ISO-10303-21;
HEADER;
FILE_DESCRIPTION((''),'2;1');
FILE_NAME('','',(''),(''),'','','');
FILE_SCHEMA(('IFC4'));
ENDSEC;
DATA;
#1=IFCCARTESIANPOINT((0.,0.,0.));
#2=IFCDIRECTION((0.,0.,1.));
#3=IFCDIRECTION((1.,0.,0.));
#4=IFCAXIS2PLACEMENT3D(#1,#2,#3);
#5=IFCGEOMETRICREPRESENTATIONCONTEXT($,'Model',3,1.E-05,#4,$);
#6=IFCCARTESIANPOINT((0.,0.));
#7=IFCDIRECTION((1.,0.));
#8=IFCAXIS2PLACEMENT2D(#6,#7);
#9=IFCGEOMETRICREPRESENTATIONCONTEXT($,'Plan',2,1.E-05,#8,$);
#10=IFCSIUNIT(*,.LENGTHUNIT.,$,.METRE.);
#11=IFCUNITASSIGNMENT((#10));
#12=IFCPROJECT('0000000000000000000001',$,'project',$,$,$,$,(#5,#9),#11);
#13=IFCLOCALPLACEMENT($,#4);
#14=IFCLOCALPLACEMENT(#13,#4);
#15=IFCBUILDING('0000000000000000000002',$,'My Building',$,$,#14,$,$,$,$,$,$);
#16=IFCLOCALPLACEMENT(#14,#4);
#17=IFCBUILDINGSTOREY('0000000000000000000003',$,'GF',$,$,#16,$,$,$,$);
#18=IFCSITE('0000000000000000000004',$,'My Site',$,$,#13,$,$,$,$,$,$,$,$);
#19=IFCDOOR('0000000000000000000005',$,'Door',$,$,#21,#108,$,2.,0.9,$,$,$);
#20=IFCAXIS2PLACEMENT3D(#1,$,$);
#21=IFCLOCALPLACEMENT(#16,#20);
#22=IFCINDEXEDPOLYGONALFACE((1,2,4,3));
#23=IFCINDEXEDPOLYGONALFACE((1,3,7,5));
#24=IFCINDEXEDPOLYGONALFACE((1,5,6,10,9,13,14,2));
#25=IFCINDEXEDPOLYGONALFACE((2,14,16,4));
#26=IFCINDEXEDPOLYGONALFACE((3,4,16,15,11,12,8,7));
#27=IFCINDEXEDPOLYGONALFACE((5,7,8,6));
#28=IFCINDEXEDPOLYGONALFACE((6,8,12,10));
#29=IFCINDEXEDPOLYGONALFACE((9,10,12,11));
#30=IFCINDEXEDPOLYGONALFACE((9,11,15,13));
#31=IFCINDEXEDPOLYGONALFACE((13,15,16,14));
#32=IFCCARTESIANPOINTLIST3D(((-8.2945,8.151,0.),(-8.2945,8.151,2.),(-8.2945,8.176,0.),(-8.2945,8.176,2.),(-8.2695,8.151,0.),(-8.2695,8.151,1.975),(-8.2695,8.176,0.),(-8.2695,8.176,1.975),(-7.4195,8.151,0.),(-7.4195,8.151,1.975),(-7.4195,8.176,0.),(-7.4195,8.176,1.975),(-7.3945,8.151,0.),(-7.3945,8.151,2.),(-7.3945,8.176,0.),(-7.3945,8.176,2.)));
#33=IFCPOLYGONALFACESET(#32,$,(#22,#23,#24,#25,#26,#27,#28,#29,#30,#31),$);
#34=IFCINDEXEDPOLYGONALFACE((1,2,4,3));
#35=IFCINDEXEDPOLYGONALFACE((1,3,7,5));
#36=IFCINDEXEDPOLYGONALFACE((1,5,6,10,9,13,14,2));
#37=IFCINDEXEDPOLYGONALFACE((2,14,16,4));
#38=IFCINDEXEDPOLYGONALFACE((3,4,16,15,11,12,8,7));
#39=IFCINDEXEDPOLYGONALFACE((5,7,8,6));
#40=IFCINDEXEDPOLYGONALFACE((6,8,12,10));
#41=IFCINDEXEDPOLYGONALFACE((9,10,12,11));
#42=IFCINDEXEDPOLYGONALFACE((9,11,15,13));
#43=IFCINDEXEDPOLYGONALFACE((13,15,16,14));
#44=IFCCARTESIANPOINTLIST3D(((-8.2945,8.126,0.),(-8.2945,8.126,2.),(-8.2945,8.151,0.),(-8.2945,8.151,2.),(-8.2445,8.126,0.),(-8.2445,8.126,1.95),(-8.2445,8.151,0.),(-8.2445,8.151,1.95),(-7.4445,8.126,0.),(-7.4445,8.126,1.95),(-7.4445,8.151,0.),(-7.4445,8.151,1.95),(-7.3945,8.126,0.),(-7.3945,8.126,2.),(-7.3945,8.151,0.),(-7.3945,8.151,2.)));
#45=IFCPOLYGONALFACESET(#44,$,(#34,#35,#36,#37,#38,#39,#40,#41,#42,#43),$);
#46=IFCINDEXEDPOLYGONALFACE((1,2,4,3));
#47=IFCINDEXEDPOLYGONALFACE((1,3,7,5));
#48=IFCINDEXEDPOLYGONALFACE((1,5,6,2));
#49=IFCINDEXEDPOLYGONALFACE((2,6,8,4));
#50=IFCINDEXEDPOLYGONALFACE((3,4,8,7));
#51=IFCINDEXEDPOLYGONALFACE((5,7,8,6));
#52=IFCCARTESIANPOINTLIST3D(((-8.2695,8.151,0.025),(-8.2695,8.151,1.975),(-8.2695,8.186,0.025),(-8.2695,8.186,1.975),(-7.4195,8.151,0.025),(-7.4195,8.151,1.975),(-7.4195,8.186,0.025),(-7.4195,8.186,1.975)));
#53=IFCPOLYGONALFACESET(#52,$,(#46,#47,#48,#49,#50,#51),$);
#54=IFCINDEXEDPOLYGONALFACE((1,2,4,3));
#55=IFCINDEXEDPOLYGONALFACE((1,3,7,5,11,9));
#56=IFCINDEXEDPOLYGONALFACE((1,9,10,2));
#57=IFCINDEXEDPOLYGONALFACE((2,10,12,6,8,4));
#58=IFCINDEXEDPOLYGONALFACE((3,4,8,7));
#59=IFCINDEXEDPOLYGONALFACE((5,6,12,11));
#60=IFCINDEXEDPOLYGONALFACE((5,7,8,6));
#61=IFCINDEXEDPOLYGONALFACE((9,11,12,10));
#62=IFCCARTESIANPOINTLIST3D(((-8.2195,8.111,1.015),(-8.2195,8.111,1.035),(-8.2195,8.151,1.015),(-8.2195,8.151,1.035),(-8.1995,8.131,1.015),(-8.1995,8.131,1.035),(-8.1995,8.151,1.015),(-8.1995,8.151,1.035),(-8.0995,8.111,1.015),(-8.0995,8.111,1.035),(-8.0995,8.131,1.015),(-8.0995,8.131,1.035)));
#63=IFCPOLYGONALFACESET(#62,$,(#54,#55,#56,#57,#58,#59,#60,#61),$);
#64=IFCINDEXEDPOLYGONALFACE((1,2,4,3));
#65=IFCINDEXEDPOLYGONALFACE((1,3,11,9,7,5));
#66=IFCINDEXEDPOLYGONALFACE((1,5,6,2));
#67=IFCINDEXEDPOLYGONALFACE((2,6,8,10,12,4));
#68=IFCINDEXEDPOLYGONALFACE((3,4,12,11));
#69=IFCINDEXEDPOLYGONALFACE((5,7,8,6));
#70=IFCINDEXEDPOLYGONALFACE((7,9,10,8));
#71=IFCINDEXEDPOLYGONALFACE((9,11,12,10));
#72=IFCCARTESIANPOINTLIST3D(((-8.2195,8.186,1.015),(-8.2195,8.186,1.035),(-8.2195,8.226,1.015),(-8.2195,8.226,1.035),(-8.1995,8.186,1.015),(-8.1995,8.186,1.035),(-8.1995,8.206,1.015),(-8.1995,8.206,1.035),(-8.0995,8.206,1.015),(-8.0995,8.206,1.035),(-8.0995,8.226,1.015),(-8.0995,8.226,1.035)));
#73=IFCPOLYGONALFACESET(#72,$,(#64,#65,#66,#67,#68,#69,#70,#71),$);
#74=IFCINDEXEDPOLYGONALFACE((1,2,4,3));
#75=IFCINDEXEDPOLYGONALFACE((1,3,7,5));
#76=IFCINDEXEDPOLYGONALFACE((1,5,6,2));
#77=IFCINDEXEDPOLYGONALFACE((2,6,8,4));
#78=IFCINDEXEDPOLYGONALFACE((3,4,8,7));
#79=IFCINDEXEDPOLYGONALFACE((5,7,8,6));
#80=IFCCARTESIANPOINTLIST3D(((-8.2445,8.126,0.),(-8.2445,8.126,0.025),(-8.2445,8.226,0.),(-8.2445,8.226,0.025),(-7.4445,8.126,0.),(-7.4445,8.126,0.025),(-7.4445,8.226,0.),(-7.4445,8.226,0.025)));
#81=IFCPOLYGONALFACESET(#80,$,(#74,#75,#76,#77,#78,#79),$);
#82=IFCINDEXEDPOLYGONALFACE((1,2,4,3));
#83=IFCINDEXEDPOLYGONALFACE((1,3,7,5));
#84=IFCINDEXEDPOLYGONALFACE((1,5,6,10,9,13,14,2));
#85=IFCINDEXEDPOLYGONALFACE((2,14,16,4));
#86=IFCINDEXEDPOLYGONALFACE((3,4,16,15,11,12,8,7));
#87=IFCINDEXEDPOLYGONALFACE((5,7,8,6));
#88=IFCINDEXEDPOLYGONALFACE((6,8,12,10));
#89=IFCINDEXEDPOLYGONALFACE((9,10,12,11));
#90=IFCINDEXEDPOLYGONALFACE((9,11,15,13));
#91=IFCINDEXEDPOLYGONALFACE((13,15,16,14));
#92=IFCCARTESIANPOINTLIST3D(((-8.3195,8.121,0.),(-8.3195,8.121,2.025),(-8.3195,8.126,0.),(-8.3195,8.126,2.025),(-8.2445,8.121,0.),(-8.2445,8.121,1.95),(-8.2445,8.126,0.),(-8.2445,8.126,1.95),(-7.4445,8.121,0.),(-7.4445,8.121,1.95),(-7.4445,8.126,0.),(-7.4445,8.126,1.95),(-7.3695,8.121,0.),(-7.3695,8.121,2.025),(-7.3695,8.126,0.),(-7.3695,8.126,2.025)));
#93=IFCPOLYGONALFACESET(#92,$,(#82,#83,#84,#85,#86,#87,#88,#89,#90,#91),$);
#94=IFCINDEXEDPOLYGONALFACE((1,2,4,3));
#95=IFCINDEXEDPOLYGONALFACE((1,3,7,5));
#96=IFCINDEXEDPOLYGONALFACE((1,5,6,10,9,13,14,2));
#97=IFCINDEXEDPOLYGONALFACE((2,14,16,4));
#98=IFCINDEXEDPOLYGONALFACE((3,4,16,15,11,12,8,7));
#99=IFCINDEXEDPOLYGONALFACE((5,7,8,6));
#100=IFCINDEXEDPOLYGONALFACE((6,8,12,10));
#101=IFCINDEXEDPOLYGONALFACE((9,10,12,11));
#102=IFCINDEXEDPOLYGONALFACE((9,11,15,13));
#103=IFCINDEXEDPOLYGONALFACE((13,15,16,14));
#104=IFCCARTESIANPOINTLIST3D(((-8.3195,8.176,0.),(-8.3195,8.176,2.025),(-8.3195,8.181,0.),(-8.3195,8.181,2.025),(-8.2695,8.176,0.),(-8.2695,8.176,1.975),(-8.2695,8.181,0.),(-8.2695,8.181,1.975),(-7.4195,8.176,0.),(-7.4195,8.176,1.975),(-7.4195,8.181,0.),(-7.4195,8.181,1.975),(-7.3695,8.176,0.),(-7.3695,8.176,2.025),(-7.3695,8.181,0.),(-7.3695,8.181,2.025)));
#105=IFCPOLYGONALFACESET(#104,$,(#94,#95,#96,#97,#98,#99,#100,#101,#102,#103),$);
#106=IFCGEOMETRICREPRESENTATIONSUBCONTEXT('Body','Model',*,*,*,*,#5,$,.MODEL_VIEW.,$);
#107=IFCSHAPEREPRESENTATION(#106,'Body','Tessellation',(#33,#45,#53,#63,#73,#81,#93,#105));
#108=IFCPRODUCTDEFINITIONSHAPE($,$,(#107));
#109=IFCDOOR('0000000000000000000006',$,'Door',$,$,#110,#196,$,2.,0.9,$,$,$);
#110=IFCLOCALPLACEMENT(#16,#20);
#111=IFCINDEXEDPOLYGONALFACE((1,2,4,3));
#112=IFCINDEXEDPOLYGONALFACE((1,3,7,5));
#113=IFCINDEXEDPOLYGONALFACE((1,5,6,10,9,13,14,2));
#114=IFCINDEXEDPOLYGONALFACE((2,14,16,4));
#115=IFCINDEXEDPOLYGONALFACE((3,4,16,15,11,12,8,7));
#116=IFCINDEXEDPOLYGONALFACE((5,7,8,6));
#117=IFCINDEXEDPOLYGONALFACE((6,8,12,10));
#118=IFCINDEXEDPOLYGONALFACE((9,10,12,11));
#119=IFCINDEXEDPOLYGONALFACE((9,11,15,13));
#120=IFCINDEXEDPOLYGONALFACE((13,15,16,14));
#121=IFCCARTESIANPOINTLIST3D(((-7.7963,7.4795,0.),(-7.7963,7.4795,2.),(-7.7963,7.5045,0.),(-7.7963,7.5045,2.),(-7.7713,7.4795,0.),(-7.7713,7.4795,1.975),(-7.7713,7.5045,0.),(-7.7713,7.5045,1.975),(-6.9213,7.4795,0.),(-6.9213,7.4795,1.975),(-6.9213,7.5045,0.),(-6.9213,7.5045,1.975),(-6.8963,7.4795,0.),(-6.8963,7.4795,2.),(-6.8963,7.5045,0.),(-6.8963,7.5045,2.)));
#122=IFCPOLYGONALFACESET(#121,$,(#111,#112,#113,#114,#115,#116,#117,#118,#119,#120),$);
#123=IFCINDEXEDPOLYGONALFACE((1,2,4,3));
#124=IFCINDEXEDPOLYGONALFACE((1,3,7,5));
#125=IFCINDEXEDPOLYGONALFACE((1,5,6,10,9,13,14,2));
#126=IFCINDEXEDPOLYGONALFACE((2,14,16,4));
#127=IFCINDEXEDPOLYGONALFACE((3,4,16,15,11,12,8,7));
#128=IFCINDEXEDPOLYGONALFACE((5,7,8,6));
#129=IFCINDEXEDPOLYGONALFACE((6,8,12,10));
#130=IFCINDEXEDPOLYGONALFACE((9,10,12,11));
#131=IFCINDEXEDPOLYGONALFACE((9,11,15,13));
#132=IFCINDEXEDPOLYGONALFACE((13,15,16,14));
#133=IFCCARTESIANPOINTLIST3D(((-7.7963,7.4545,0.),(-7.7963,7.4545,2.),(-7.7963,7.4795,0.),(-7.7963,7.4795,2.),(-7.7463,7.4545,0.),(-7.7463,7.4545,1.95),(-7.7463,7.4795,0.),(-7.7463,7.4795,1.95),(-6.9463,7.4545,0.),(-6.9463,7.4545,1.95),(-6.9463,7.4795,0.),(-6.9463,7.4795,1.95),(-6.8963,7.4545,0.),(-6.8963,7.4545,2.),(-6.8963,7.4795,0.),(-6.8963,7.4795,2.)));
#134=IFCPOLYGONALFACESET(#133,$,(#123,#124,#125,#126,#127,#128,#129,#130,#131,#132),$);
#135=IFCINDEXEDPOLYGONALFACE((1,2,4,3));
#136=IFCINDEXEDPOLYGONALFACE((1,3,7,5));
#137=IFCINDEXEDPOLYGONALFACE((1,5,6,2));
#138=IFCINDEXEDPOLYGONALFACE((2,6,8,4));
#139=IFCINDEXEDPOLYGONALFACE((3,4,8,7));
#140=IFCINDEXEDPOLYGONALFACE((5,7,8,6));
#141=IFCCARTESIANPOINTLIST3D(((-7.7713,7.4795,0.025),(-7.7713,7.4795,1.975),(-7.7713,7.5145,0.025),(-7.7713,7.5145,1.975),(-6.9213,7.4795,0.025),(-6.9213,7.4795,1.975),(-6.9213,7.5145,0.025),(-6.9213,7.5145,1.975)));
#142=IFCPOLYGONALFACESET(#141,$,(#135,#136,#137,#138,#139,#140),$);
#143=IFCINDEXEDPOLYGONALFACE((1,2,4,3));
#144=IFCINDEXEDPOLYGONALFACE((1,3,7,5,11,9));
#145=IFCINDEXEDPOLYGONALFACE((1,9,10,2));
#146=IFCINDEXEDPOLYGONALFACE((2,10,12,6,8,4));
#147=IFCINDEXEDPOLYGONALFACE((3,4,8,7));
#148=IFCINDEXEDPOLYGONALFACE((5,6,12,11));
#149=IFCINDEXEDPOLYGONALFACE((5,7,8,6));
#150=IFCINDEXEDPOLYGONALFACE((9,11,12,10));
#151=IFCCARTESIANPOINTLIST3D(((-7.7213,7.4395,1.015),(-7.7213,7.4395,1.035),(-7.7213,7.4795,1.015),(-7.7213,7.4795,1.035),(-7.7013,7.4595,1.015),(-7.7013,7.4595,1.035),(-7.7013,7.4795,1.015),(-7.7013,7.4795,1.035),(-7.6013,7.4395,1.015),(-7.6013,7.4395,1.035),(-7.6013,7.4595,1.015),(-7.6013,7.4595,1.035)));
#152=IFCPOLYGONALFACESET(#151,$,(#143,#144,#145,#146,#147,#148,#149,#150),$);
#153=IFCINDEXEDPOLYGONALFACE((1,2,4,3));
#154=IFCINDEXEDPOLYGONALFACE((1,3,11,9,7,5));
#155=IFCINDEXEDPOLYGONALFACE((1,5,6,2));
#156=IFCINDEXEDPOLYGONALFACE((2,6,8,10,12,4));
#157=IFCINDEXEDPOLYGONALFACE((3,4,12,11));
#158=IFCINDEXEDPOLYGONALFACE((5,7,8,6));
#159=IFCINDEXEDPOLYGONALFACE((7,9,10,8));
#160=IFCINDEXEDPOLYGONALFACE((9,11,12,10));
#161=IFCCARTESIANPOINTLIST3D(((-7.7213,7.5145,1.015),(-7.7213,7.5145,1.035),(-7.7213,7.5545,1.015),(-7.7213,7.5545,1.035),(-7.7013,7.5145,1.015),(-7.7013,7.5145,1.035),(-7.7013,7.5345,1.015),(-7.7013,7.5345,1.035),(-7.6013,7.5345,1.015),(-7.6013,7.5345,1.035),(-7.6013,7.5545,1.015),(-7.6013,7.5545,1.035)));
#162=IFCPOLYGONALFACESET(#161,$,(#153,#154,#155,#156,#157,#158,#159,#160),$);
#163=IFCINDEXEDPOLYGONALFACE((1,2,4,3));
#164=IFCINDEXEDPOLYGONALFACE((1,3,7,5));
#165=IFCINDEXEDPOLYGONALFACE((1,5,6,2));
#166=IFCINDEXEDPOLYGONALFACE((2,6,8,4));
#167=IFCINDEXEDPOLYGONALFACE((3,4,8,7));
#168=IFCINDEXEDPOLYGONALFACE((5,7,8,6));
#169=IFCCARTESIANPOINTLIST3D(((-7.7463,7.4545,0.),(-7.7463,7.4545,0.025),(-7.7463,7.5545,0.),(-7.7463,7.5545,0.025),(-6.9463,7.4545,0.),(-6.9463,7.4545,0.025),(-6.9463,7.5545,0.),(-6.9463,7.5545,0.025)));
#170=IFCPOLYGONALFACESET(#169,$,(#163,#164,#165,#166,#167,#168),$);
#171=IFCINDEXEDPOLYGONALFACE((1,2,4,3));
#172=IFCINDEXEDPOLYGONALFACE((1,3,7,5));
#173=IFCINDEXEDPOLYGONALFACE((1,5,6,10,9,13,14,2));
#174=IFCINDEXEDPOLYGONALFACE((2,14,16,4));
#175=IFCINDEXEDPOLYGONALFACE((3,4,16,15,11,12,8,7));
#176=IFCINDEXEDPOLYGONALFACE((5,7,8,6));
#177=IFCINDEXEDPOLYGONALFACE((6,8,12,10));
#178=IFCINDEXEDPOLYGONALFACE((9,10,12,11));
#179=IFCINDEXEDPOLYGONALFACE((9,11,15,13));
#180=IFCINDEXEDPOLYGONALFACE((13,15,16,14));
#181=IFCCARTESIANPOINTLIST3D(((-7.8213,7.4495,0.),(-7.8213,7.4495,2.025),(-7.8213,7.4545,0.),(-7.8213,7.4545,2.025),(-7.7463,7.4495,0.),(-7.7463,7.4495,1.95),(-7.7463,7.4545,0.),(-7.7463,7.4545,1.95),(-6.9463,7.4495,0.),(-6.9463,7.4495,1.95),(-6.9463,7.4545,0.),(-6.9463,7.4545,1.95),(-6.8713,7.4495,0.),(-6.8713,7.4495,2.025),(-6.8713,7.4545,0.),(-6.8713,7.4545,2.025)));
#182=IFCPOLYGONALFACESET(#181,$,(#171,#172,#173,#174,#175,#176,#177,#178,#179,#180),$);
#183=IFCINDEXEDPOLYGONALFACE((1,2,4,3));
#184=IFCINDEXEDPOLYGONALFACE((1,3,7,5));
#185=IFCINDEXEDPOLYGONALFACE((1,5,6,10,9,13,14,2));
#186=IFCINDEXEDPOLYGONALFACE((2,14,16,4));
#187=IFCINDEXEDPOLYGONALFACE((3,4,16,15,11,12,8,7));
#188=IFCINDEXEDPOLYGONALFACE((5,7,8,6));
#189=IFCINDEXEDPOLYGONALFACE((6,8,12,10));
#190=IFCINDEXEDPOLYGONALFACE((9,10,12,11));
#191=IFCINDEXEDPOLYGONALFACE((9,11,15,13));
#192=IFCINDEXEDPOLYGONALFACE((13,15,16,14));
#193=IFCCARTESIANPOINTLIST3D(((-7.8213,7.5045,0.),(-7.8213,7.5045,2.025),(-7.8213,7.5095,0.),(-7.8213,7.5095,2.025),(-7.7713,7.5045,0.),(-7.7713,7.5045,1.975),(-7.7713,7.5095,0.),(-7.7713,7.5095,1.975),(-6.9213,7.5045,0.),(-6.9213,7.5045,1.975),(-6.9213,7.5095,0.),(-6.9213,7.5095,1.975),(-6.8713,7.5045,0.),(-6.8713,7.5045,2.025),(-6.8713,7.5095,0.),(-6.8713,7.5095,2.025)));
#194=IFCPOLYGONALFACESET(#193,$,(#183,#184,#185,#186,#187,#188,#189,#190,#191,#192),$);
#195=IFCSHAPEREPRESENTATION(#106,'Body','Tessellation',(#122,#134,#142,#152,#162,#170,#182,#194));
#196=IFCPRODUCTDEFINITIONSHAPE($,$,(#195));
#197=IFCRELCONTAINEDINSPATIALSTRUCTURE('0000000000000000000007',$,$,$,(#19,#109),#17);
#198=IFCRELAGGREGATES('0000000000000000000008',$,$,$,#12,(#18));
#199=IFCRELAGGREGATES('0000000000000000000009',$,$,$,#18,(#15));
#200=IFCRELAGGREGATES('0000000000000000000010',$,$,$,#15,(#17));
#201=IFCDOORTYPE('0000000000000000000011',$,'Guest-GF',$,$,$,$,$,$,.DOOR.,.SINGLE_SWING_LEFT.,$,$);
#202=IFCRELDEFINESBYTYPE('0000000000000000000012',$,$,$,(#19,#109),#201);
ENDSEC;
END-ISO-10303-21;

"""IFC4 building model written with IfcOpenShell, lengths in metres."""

from ifc_helpers import new_model, entity, si_unit, frame, origin_with_axes, origin_2d_with_axis, place, context, subcontext, project, spatial, line, indexed_curve, outline, extrude, shape, source, transform, mapped, type_object, type_shapes, element, save


model = new_model("IFC4")

# Units and contexts
model_context = context("Model", 3, precision=1e-05, world=origin_with_axes())
plan_context = context("Plan", 2, precision=1e-05, world=origin_2d_with_axis())
body_context_1 = subcontext(model_context, "Body", "Model", "MODEL_VIEW")
body_context_2 = subcontext(plan_context, "Body", "Plan", "PLAN_VIEW")
ifc_project = project(units=[si_unit("LENGTHUNIT", "METRE")], contexts=[model_context, plan_context])

# Site, building, storey
site_placement = place(None, origin_with_axes())
site = spatial("IfcSite", under=ifc_project, at=site_placement, Name="My Site")
building_placement = place(site_placement, origin_with_axes())
building = spatial("IfcBuilding", under=site, at=building_placement, Name="My Building")
storey_placement = place(building_placement, origin_with_axes())
storey = spatial("IfcBuildingStorey", under=building, at=storey_placement, Name="GF")

# Doors
door_type_1 = type_object("IfcDoorType", Name="Guest-GF", OperationType="SINGLE_SWING_LEFT", PredefinedType="DOOR")
shared_shape_1 = source(origin_with_axes(), body_context_1, "Body", "SweptSolid", [
    extrude(outline(indexed_curve([(0.0, 0.0), (0.0, 2.0), (0.9, 2.0), (0.9, 0.0), (0.875, 0.0), (0.875, 1.975), (0.025, 1.975), (0.025, 0.0)], segments=[line(1, 2, 3, 4, 5, 6, 7, 8, 1)])), frame((0.0, 0.025, 0.0), z_axis=(0.0, -1.0, 0.0), x_axis=(1.0, 0.0, 0.0)), (0.0, 0.0, -1.0), 0.025),
    extrude(outline(indexed_curve([(0.0, 0.0), (0.0, 2.0), (0.9, 2.0), (0.9, 0.0), (0.85, 0.0), (0.85, 1.95), (0.05, 1.95), (0.05, 0.0)], segments=[line(1, 2, 3, 4, 5, 6, 7, 8, 1)])), frame((0.0, 0.0, 0.0), z_axis=(0.0, -1.0, 0.0), x_axis=(1.0, 0.0, 0.0)), (0.0, 0.0, -1.0), 0.025),
    extrude(outline(indexed_curve([(0.0, 0.0), (0.85, 0.0), (0.85, 0.035), (0.0, 0.035)], segments=[line(1, 2, 3, 4, 1)])), frame((0.025, 0.025, 0.025), z_axis=(0.0, 0.0, 1.0), x_axis=(1.0, 0.0, 0.0)), (0.0, 0.0, 1.0), 1.95),
    extrude(outline(indexed_curve([(0.0, 0.0), (0.0, -0.04), (0.12, -0.04), (0.12, -0.02), (0.02, -0.02), (0.02, 0.0)], segments=[line(1, 2, 3, 4, 5, 6, 1)])), frame((0.075, 0.025, 1.015), z_axis=(0.0, 0.0, 1.0), x_axis=(1.0, 0.0, 0.0)), (0.0, 0.0, 1.0), 0.02),
    extrude(outline(indexed_curve([(0.0, 0.0), (0.0, 0.04), (0.12, 0.04), (0.12, 0.02), (0.02, 0.02), (0.02, 0.0)], segments=[line(1, 2, 3, 4, 5, 6, 1)])), frame((0.075, 0.06, 1.015), z_axis=(0.0, 0.0, 1.0), x_axis=(1.0, 0.0, 0.0)), (0.0, 0.0, 1.0), 0.02),
    extrude(outline(indexed_curve([(0.0, 0.0), (0.8, 0.0), (0.8, 0.1), (0.0, 0.1)], segments=[line(1, 2, 3, 4, 1)])), frame((0.05, 0.0, 0.0), z_axis=(0.0, 0.0, 1.0), x_axis=(1.0, 0.0, 0.0)), (0.0, 0.0, 1.0), 0.025),
    extrude(outline(indexed_curve([(0.0, 0.0), (0.0, 2.025), (0.95, 2.025), (0.95, 0.0), (0.875, 0.0), (0.875, 1.95), (0.075, 1.95), (0.075, 0.0)], segments=[line(1, 2, 3, 4, 5, 6, 7, 8, 1)])), frame((-0.025, -0.005, 0.0), z_axis=(0.0, -1.0, 0.0), x_axis=(1.0, 0.0, 0.0)), (0.0, 0.0, -1.0), 0.005),
    extrude(outline(indexed_curve([(0.0, 0.0), (0.0, 2.025), (0.95, 2.025), (0.95, 0.0), (0.9, 0.0), (0.9, 1.975), (0.05, 1.975), (0.05, 0.0)], segments=[line(1, 2, 3, 4, 5, 6, 7, 8, 1)])), frame((-0.025, 0.05, 0.0), z_axis=(0.0, -1.0, 0.0), x_axis=(1.0, 0.0, 0.0)), (0.0, 0.0, -1.0), 0.005),
])
shared_shape_2 = source(origin_with_axes(), body_context_2, "Body", "Curve2D", [
    entity("IfcIndexedPolyCurve", entity("IfcCartesianPointList2D", [[0.0, 0.0], [0.0, 0.05], [0.025, 0.05], [0.025, 0.025], [0.05, 0.025], [0.05, 0.0]]), [entity("IfcLineIndex", [1, 2, 3, 4, 5, 6, 1])]),
    entity("IfcIndexedPolyCurve", entity("IfcCartesianPointList2D", [[0.9, 0.0], [0.9, 0.05], [0.875, 0.05], [0.875, 0.025], [0.85, 0.025], [0.85, 0.0]]), [entity("IfcLineIndex", [1, 2, 3, 4, 5, 6, 1])]),
    entity("IfcTrimmedCurve", entity("IfcEllipse", entity("IfcAxis2Placement2D", entity("IfcCartesianPoint", [0.84, 0.05]), entity("IfcDirection", [1.0, 0.0])), 0.815, 0.85), [entity("IfcCartesianPoint", [0.84, 0.9])], [entity("IfcCartesianPoint", [0.025, 0.05])], True, "CARTESIAN"),
    entity("IfcIndexedPolyCurve", entity("IfcCartesianPointList2D", [[0.875, 0.05], [0.84, 0.05], [0.84, 0.9], [0.875, 0.9]]), [entity("IfcLineIndex", [1, 2, 3, 4, 1])]),
])
type_shapes(door_type_1, [shared_shape_1, shared_shape_2])
for number, where, z_axis, x_axis, name in (
    (1, (-8.2945, 8.126, 0.0), (0.0, 0.0, 1.0), (1.0, 0.0, 0.0), "Door"),
    (2, (-7.7963, 7.4545, 0.0), (0.0, 0.0, 1.0), (1.0, 0.0, 0.0), "Door"),
):
    element("IfcDoor", number, at=place(storey_placement, frame(where, z_axis=z_axis, x_axis=x_axis)), inside=storey, type_object=door_type_1, Name=name, OverallHeight=2.0, OverallWidth=0.9, shapes=[
        shape(body_context_1, "Body", "MappedRepresentation", [mapped(shared_shape_1, transform((0.0, 0.0, 0.0), x_axis=(1.0, 0.0, 0.0), y_axis=(0.0, 1.0, 0.0), z_axis=(0.0, 0.0, 1.0), scale=1.0))]),
        shape(body_context_2, "Body", "MappedRepresentation", [mapped(shared_shape_2, transform((0.0, 0.0, 0.0), x_axis=(1.0, 0.0, 0.0), y_axis=(0.0, 1.0, 0.0), z_axis=(0.0, 0.0, 1.0), scale=1.0))]),
    ])

save(model, "model.ifc")
